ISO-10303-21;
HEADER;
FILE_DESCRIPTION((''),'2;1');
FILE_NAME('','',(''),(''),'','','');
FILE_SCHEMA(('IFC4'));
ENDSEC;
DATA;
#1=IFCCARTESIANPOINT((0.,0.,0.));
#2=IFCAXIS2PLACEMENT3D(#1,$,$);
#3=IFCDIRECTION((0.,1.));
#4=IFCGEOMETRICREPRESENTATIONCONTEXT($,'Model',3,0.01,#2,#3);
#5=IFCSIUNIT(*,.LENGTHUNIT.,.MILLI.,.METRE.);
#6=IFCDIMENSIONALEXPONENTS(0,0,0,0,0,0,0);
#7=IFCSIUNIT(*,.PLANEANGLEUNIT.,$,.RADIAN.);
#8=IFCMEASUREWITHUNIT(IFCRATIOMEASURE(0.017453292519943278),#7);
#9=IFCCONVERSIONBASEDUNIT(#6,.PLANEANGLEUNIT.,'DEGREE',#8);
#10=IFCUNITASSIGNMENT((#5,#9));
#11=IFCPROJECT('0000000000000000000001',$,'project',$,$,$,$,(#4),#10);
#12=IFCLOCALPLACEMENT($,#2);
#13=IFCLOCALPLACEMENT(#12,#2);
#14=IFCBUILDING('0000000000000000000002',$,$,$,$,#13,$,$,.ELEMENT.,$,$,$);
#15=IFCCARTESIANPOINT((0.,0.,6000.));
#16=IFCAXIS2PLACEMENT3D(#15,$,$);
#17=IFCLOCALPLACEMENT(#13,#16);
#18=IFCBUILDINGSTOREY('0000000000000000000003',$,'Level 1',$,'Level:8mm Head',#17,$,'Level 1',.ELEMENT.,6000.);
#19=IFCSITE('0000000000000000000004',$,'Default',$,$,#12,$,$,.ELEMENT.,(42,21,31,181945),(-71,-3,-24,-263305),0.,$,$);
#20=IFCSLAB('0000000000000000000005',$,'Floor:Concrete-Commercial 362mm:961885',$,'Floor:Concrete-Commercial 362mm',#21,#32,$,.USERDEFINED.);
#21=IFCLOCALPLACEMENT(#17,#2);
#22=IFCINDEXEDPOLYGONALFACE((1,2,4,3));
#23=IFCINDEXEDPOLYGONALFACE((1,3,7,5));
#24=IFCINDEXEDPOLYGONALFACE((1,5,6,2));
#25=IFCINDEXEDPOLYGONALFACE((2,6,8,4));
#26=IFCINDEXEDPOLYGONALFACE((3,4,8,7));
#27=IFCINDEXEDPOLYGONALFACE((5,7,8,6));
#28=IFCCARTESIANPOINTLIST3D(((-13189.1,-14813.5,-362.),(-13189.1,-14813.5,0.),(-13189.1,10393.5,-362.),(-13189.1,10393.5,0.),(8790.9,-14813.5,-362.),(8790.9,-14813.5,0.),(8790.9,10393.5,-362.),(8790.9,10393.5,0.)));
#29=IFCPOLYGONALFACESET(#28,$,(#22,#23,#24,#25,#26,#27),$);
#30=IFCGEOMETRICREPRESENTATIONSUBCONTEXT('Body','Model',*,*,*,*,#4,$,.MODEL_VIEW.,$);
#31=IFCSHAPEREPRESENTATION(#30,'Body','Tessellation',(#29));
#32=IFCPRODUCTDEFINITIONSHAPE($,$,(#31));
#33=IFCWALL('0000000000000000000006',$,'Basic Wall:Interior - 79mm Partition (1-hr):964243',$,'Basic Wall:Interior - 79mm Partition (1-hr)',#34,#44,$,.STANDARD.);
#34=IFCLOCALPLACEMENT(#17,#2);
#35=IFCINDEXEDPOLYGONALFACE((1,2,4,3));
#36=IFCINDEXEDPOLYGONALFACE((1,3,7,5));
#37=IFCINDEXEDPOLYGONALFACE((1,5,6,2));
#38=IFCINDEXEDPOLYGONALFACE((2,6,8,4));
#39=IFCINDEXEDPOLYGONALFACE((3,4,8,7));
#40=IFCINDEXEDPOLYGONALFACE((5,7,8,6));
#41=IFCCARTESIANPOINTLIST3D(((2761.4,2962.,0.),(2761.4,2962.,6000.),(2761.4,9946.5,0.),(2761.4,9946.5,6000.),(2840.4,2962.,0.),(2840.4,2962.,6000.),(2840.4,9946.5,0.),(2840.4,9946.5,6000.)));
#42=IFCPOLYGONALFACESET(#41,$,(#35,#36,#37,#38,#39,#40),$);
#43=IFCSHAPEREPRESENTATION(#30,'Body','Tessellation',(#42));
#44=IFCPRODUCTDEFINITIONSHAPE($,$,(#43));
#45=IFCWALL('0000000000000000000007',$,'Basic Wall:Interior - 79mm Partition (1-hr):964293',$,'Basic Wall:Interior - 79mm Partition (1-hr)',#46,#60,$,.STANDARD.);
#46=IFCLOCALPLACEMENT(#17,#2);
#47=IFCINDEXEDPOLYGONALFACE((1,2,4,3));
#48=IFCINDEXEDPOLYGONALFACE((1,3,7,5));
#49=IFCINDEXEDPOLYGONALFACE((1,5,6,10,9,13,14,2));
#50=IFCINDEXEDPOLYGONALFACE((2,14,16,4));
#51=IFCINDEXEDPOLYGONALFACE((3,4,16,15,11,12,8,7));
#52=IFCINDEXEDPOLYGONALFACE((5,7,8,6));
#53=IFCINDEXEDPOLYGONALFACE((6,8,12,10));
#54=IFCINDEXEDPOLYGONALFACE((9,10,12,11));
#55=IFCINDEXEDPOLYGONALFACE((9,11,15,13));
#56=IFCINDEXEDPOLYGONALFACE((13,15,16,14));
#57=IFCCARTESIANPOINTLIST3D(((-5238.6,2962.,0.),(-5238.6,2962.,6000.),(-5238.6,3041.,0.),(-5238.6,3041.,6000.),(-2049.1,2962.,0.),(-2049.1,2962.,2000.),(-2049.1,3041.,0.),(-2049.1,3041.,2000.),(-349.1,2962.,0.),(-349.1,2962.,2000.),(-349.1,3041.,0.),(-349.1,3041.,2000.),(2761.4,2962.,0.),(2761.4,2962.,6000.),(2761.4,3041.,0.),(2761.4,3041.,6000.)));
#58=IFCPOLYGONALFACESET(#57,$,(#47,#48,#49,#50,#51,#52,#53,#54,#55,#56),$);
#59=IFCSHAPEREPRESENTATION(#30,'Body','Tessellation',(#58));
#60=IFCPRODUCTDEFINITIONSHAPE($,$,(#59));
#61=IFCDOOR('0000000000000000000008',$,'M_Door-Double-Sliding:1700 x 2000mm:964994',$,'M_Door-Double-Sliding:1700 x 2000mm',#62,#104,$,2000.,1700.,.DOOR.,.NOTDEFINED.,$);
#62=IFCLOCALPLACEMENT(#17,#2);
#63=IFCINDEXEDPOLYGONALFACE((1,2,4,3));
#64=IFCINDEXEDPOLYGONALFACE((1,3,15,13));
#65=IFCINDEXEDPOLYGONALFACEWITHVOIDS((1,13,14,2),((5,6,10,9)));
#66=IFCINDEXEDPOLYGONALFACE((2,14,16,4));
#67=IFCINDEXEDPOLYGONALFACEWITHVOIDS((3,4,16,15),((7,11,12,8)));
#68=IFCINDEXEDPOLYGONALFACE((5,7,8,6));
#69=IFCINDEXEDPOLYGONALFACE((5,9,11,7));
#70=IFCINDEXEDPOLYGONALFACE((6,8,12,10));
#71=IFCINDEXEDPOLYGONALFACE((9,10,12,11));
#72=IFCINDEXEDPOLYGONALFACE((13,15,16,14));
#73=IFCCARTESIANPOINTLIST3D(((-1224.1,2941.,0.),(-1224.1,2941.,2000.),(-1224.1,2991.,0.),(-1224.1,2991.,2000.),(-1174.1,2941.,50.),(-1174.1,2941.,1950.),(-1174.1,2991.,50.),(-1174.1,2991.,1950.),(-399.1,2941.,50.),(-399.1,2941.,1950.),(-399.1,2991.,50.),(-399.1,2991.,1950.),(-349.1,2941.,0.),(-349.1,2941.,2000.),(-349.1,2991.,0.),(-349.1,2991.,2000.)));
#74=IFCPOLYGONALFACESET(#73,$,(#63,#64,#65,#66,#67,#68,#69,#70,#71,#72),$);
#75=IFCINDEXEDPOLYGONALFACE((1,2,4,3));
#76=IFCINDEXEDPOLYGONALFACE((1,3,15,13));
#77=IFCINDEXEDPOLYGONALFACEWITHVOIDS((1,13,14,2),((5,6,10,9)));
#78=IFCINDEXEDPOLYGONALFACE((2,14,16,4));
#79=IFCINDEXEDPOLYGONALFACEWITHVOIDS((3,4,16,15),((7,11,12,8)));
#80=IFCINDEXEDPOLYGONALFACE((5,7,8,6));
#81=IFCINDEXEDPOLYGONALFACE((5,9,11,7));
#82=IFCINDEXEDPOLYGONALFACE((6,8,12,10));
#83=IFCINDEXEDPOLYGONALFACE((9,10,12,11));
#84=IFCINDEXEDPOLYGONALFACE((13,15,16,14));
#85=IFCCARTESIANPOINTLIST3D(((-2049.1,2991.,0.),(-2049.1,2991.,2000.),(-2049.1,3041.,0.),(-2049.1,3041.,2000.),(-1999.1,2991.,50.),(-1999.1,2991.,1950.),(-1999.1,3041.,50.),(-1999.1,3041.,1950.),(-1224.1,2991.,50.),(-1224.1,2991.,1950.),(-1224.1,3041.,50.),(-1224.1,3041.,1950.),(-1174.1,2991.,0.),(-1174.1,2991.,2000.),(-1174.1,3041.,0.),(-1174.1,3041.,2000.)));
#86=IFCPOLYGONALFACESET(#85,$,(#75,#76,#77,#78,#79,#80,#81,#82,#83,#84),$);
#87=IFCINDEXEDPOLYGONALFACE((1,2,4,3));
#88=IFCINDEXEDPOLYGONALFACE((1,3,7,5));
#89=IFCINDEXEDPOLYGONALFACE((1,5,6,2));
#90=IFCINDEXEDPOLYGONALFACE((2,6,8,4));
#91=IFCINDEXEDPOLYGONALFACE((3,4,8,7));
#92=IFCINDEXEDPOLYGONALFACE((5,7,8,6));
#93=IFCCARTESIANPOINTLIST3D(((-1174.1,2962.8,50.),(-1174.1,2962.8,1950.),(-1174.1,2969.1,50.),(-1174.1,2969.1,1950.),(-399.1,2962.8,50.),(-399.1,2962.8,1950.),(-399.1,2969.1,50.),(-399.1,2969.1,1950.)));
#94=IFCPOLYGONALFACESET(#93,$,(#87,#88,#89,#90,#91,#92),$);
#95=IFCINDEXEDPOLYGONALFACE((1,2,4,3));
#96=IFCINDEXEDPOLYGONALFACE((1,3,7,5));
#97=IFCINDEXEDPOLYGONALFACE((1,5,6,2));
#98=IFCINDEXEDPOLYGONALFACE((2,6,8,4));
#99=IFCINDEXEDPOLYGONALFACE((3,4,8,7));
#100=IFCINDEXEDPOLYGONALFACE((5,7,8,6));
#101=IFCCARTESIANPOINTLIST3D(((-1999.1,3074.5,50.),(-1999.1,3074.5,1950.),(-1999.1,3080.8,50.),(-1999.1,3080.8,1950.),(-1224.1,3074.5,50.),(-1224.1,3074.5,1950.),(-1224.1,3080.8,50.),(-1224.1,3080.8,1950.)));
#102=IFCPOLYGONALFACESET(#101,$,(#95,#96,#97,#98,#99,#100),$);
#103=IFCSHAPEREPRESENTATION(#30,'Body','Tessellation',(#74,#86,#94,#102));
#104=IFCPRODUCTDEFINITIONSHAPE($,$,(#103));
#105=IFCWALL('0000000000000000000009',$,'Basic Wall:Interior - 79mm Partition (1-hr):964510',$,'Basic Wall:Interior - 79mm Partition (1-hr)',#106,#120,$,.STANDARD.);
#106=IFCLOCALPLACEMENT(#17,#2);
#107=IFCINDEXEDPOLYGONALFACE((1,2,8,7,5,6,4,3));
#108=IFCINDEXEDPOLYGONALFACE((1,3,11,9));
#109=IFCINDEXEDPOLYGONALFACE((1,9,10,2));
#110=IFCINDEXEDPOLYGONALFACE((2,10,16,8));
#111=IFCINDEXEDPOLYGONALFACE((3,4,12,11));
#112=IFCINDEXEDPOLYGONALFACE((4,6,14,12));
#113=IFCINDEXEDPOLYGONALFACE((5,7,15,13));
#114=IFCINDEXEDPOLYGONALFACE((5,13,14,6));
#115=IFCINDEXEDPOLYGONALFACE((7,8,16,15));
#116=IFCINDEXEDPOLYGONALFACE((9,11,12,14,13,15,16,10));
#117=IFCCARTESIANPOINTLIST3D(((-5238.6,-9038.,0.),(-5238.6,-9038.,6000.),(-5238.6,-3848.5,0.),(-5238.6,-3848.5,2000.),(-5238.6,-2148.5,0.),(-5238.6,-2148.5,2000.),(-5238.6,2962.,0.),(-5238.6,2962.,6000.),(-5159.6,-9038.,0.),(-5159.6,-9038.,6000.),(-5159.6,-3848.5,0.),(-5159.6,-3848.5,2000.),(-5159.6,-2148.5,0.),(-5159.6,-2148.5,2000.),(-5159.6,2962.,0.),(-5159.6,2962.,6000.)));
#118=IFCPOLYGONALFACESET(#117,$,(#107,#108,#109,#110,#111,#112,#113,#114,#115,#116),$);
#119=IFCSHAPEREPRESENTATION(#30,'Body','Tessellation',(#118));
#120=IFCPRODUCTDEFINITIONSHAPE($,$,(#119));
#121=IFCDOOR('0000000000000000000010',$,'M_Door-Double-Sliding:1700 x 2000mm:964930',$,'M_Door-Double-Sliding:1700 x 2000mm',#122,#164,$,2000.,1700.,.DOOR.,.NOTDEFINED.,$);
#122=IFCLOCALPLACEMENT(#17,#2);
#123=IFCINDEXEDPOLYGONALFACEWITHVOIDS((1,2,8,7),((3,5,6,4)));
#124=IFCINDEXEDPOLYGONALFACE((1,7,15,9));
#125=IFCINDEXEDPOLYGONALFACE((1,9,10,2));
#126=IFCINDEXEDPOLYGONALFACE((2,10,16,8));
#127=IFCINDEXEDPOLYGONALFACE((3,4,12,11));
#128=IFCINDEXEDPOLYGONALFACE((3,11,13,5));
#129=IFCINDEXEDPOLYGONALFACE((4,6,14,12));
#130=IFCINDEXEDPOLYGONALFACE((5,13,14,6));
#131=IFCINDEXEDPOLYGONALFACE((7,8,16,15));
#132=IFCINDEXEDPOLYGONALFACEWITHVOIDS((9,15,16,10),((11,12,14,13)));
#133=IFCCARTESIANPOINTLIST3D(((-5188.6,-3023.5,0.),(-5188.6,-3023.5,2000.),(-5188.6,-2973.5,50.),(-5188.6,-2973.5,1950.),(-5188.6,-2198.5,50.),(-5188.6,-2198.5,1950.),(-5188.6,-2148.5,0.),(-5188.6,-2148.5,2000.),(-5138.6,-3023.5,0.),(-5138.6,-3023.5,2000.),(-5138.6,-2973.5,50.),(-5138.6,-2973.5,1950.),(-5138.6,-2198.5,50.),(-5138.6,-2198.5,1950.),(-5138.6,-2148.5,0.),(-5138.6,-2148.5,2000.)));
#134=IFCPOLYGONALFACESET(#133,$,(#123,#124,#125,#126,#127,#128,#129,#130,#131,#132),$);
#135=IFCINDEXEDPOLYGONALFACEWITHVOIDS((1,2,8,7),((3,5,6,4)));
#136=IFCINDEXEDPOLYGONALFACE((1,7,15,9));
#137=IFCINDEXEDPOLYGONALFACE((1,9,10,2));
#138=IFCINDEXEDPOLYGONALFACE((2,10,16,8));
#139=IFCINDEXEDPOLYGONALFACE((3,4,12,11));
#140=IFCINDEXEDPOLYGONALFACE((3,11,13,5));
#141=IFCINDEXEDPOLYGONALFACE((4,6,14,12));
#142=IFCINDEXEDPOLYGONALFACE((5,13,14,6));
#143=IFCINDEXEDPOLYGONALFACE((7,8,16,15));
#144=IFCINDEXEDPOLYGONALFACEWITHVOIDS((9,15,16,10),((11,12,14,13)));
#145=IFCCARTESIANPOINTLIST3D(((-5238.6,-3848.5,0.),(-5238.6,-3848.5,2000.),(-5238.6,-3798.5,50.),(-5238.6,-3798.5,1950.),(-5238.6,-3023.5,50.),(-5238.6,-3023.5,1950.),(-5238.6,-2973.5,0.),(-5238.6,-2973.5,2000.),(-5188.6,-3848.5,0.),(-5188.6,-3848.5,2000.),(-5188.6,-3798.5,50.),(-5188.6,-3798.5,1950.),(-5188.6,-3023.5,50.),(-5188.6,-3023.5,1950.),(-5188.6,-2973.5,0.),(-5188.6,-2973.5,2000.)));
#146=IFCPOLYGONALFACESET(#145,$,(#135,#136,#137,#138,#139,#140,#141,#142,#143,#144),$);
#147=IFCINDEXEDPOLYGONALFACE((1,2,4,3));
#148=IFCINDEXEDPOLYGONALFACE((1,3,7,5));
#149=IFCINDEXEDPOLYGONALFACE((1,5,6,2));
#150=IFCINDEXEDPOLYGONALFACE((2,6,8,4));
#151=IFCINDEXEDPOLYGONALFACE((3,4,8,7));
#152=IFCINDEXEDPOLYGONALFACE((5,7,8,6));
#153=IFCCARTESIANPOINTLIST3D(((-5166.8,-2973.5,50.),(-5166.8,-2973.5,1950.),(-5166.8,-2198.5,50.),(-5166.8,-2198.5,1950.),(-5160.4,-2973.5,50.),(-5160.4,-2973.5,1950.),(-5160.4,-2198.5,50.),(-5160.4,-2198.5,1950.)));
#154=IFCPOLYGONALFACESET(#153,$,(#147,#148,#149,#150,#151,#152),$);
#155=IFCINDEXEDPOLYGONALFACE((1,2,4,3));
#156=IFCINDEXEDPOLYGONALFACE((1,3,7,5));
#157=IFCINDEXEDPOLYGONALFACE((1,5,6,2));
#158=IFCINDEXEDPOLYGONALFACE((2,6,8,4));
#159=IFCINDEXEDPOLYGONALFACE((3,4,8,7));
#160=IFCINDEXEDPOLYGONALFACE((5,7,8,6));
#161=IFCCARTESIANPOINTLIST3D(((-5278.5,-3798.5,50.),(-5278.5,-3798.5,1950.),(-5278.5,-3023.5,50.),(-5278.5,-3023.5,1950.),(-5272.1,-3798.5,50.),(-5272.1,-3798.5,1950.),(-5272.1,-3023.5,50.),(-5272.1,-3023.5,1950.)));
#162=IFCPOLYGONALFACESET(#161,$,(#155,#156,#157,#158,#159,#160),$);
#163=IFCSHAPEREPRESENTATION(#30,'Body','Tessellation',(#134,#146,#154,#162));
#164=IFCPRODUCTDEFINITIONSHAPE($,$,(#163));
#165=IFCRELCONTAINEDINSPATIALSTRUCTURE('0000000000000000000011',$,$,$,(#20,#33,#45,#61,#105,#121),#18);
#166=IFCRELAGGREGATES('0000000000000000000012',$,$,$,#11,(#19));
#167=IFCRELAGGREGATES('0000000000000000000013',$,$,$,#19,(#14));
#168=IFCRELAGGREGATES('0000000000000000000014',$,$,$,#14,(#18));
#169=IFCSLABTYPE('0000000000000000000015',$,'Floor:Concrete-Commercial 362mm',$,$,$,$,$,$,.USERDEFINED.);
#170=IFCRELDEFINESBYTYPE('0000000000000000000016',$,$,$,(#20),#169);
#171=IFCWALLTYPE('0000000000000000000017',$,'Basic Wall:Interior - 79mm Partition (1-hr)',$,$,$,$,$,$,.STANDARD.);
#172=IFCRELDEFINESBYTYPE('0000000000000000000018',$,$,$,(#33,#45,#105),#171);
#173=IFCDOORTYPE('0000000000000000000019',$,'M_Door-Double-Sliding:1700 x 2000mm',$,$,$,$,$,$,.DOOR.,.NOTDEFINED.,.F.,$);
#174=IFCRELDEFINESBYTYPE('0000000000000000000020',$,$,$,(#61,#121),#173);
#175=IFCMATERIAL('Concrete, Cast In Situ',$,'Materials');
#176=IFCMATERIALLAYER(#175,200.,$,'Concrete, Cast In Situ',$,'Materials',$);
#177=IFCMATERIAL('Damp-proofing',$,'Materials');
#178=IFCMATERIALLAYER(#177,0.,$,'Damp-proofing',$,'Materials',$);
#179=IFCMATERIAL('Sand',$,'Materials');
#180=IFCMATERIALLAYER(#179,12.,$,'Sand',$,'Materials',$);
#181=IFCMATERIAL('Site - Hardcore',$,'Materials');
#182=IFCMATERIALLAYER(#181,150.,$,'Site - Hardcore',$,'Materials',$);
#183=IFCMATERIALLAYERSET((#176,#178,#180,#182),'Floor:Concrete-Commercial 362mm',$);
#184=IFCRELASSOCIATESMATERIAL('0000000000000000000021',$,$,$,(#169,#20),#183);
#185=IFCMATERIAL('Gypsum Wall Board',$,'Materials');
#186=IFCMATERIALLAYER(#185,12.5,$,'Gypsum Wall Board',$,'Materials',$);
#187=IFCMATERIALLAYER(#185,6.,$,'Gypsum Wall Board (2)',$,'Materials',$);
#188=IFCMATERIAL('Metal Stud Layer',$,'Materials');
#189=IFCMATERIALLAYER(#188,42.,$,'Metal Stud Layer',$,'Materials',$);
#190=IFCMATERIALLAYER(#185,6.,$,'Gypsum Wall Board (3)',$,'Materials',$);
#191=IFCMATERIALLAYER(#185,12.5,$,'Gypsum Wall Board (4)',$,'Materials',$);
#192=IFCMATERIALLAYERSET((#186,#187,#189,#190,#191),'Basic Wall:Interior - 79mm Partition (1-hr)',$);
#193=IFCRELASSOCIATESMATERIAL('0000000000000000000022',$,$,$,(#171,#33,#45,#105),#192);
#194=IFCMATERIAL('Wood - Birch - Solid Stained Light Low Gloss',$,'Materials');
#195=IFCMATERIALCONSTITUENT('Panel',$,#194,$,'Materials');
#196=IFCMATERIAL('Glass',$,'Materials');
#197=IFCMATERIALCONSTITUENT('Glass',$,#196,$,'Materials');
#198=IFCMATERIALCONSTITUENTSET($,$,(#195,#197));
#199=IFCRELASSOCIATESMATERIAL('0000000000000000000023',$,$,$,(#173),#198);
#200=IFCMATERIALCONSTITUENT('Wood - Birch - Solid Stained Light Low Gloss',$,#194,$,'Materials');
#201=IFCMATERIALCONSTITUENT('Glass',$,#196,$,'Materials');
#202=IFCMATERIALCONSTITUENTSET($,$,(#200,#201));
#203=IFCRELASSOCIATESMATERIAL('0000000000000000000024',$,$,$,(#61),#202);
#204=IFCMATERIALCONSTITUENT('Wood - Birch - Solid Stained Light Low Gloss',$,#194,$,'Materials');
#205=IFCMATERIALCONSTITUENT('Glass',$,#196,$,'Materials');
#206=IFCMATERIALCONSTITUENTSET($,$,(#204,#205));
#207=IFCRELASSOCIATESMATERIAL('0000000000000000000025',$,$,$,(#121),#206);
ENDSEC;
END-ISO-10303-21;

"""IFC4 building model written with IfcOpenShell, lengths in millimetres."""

from ifc_helpers import new_model, entity, si_unit, converted_unit, direction, frame, frame_2d, origin, origin_2d_with_axis, place, context, subcontext, project, spatial, polyline, rectangle, outline, extrude, source, transform, mapped, material, layer, layer_set, layer_usage, constituent, constituent_set, type_object, type_shapes, element, fill, save


model = new_model("IFC4")

# Units and contexts
model_context = context("Model", 3, precision=0.01, world=origin(), true_north=direction((0.0, 1.0)))
body_context = subcontext(model_context, "Body", "Model", "MODEL_VIEW")
ifc_project = project(units=[si_unit("LENGTHUNIT", "METRE", prefix="MILLI"), converted_unit("PLANEANGLEUNIT", "DEGREE", entity("IfcRatioMeasure", 0.017453292519943278), si_unit("PLANEANGLEUNIT", "RADIAN"), dimensions=[0, 0, 0, 0, 0, 0, 0])], contexts=[model_context])

# Site, building, storey
site_placement = place(None, origin())
site = spatial("IfcSite", under=ifc_project, at=site_placement, Name="Default", CompositionType="ELEMENT", RefLatitude=(42, 21, 31, 181945), RefLongitude=(-71, -3, -24, -263305), RefElevation=0.0)
building_placement = place(site_placement, origin())
building = spatial("IfcBuilding", under=site, at=building_placement, CompositionType="ELEMENT")
storey_placement = place(building_placement, frame((0.0, 0.0, 6000.0)))
storey = spatial("IfcBuildingStorey", under=building, at=storey_placement, Name="Level 1", ObjectType="Level:8mm Head", LongName="Level 1", CompositionType="ELEMENT", Elevation=6000.0)

# Slab
ifc_material_1 = material(Name="Concrete, Cast In Situ", Category="Materials")
ifc_layer_1 = layer(ifc_material_1, 200.0, Name="Concrete, Cast In Situ", Category="Materials")
ifc_material_2 = material(Name="Damp-proofing", Category="Materials")
ifc_layer_2 = layer(ifc_material_2, 0.0, Name="Damp-proofing", Category="Materials")
ifc_material_3 = material(Name="Sand", Category="Materials")
ifc_layer_3 = layer(ifc_material_3, 12.0, Name="Sand", Category="Materials")
ifc_material_4 = material(Name="Site - Hardcore", Category="Materials")
ifc_layer_4 = layer(ifc_material_4, 150.0, Name="Site - Hardcore", Category="Materials")
ifc_layer_set_1 = layer_set([ifc_layer_1, ifc_layer_2, ifc_layer_3, ifc_layer_4], Name="Floor:Concrete-Commercial 362mm")
ifc_layer_usage_1 = layer_usage(ifc_layer_set_1, "AXIS3", "POSITIVE", 0.0)
slab_type = type_object("IfcSlabType", Name="Floor:Concrete-Commercial 362mm", PredefinedType="USERDEFINED", material=ifc_layer_set_1)
slab_placement = place(storey_placement, origin())
element("IfcSlab", 1, at=slab_placement, inside=storey, type_object=slab_type, material=ifc_layer_usage_1, Name="Floor:Concrete-Commercial 362mm:961885", ObjectType="Floor:Concrete-Commercial 362mm", PredefinedType="USERDEFINED", context=body_context, shape_type="SweptSolid", body=[
    extrude(rectangle(XDim=25207.0, YDim=21980.0, at=frame_2d((0.0, 0.0), x_axis=(1.0, 0.0))), frame((-2199.1, -2210.0, 0.0), z_axis=(0.0, 0.0, -1.0), x_axis=(0.0, 1.0, 0.0)), (0.0, 0.0, 1.0), 362.0),
])

# Wall
ifc_material_5 = material(Name="Gypsum Wall Board", Category="Materials")
ifc_layer_5 = layer(ifc_material_5, 12.5, Name="Gypsum Wall Board", Category="Materials")
ifc_layer_6 = layer(ifc_material_5, 6.0, Name="Gypsum Wall Board (2)", Category="Materials")
ifc_material_6 = material(Name="Metal Stud Layer", Category="Materials")
ifc_layer_7 = layer(ifc_material_6, 42.0, Name="Metal Stud Layer", Category="Materials")
ifc_layer_8 = layer(ifc_material_5, 6.0, Name="Gypsum Wall Board (3)", Category="Materials")
ifc_layer_9 = layer(ifc_material_5, 12.5, Name="Gypsum Wall Board (4)", Category="Materials")
ifc_layer_set_2 = layer_set([ifc_layer_5, ifc_layer_6, ifc_layer_7, ifc_layer_8, ifc_layer_9], Name="Basic Wall:Interior - 79mm Partition (1-hr)")
ifc_layer_usage_2 = layer_usage(ifc_layer_set_2, "AXIS2", "NEGATIVE", 39.5)
wall_type = type_object("IfcWallType", Name="Basic Wall:Interior - 79mm Partition (1-hr)", PredefinedType="STANDARD", material=ifc_layer_set_2)
wall_1_placement = place(storey_placement, frame((2800.9, 9946.5, 0.0), z_axis=(0.0, 0.0, 1.0), x_axis=(0.0, -1.0, 0.0)))
element("IfcWall", 2, at=wall_1_placement, inside=storey, type_object=wall_type, material=ifc_layer_usage_2, Name="Basic Wall:Interior - 79mm Partition (1-hr):964243", ObjectType="Basic Wall:Interior - 79mm Partition (1-hr)", PredefinedType="STANDARD", context=body_context, shape_type="SweptSolid", body=[
    extrude(rectangle(XDim=6984.5, YDim=79.0, at=frame_2d((3492.3, 0.0), x_axis=(-1.0, 0.0))), origin(), (0.0, 0.0, 1.0), 6000.0),
])

# Walls, openings, doors
wall_2_placement = place(storey_placement, frame((2761.4, 3001.5, 0.0), z_axis=(0.0, 0.0, 1.0), x_axis=(-1.0, 0.0, 0.0)))
wall_2 = element("IfcWall", 3, at=wall_2_placement, inside=storey, type_object=wall_type, material=ifc_layer_usage_2, Name="Basic Wall:Interior - 79mm Partition (1-hr):964293", ObjectType="Basic Wall:Interior - 79mm Partition (1-hr)", PredefinedType="STANDARD", context=body_context, shape_type="SweptSolid", body=[
    extrude(rectangle(XDim=8000.0, YDim=79.0, at=frame_2d((4000.0, 0.0), x_axis=(-1.0, 0.0))), origin(), (0.0, 0.0, 1.0), 6000.0),
])
opening_1_placement = place(wall_2_placement, frame((4810.5, 39.5, 0.0)))
opening_1 = element("IfcOpeningElement", 4, at=opening_1_placement, cuts=wall_2, PredefinedType="OPENING", context=body_context, shape_type="SweptSolid", body=[
    extrude(rectangle(XDim=2000.0, YDim=1700.0, at=frame_2d((1000.0, 850.0), x_axis=(-1.0, 0.0))), frame((0.0, 0.0, 0.0), z_axis=(0.0, -1.0, 0.0), x_axis=(0.0, 0.0, 1.0)), (0.0, 0.0, 1.0), 79.0),
])
ifc_material_7 = material(Name="Wood - Birch - Solid Stained Light Low Gloss", Category="Materials")
ifc_constituent_1 = constituent(ifc_material_7, Name="Wood - Birch - Solid Stained Light Low Gloss", Category="Materials")
ifc_material_8 = material(Name="Glass", Category="Materials")
ifc_constituent_2 = constituent(ifc_material_8, Name="Glass", Category="Materials")
ifc_constituent_set_1 = constituent_set(constituents=[ifc_constituent_1, ifc_constituent_2])
ifc_constituent_3 = constituent(ifc_material_7, Name="Panel", Category="Materials")
ifc_constituent_4 = constituent(ifc_material_8, Name="Glass", Category="Materials")
ifc_constituent_set_2 = constituent_set(constituents=[ifc_constituent_3, ifc_constituent_4])
door_type = type_object("IfcDoorType", Name="M_Door-Double-Sliding:1700 x 2000mm", OperationType="NOTDEFINED", ParameterTakesPrecedence=False, PredefinedType="DOOR", material=ifc_constituent_set_2)
shared_shape_1 = source(origin(), body_context, "Body", "SweptSolid", [
    extrude(outline(polyline([(-437.5, -1000.0), (437.5, -1000.0), (437.5, 1000.0), (-437.5, 1000.0), (-437.5, -1000.0)]), holes=[polyline([(-387.5, -950.0), (-387.5, 950.0), (387.5, 950.0), (387.5, -950.0), (-387.5, -950.0)])]), frame((1262.5, -21.0, 1000.0), z_axis=(0.0, 1.0, 0.0), x_axis=(1.0, 0.0, 0.0)), (0.0, 0.0, 1.0), 50.0),
    extrude(outline(polyline([(-1000.0, -437.5), (1000.0, -437.5), (1000.0, 437.5), (-1000.0, 437.5), (-1000.0, -437.5)]), holes=[polyline([(-950.0, -387.5), (-950.0, 387.5), (950.0, 387.5), (950.0, -387.5), (-950.0, -387.5)])]), frame((437.5, 29.0, 1000.0), z_axis=(0.0, 1.0, 0.0), x_axis=(0.0, 0.0, -1.0)), (0.0, 0.0, 1.0), 50.0),
    extrude(rectangle(XDim=6.3, YDim=775.0, at=frame_2d((0.0, 0.0), x_axis=(1.0, 0.0))), frame((1262.5, 4.0, 50.0), z_axis=(0.0, 0.0, 1.0), x_axis=(0.0, -1.0, 0.0)), (0.0, 0.0, 1.0), 1900.0),
    extrude(rectangle(XDim=6.4, YDim=775.0, at=origin_2d_with_axis()), frame((437.5, 115.7, 50.0), z_axis=(0.0, 0.0, 1.0), x_axis=(0.0, 1.0, 0.0)), (0.0, 0.0, 1.0), 1900.0),
])
type_shapes(door_type, [shared_shape_1])
door_1_placement = place(opening_1_placement, frame((0.0, 0.0, 0.0), z_axis=(0.0, 0.0, 1.0), x_axis=(-1.0, 0.0, 0.0)))
door_1 = element("IfcDoor", 5, at=door_1_placement, inside=storey, type_object=door_type, material=ifc_constituent_set_1, Name="M_Door-Double-Sliding:1700 x 2000mm:964994", ObjectType="M_Door-Double-Sliding:1700 x 2000mm", OperationType="NOTDEFINED", OverallHeight=2000.0, OverallWidth=1700.0, PredefinedType="DOOR", context=body_context, shape_type="MappedRepresentation", body=[
    mapped(shared_shape_1, transform((0.0, 0.0, 0.0), scale=1.0)),
])
fill(opening_1, door_1)
wall_3_placement = place(storey_placement, frame((-5199.1, 2962.0, 0.0), z_axis=(0.0, 0.0, 1.0), x_axis=(0.0, -1.0, 0.0)))
wall_3 = element("IfcWall", 6, at=wall_3_placement, inside=storey, type_object=wall_type, material=ifc_layer_usage_2, Name="Basic Wall:Interior - 79mm Partition (1-hr):964510", ObjectType="Basic Wall:Interior - 79mm Partition (1-hr)", PredefinedType="STANDARD", context=body_context, shape_type="SweptSolid", body=[
    extrude(rectangle(XDim=12000.0, YDim=79.0, at=frame_2d((6000.0, 0.0), x_axis=(1.0, 0.0))), origin(), (0.0, 0.0, 1.0), 6000.0),
])
opening_2_placement = place(wall_3_placement, frame((6810.5, 39.5, 0.0)))
opening_2 = element("IfcOpeningElement", 7, at=opening_2_placement, cuts=wall_3, PredefinedType="OPENING", context=body_context, shape_type="SweptSolid", body=[
    extrude(rectangle(XDim=2000.0, YDim=1700.0, at=frame_2d((1000.0, 850.0), x_axis=(-1.0, 0.0))), frame((0.0, 0.0, 0.0), z_axis=(0.0, -1.0, 0.0), x_axis=(0.0, 0.0, 1.0)), (0.0, 0.0, 1.0), 79.0),
])
ifc_constituent_5 = constituent(ifc_material_7, Name="Wood - Birch - Solid Stained Light Low Gloss", Category="Materials")
ifc_constituent_6 = constituent(ifc_material_8, Name="Glass", Category="Materials")
ifc_constituent_set_3 = constituent_set(constituents=[ifc_constituent_5, ifc_constituent_6])
door_2_placement = place(opening_2_placement, frame((0.0, 0.0, 0.0), z_axis=(0.0, 0.0, 1.0), x_axis=(-1.0, 0.0, 0.0)))
door_2 = element("IfcDoor", 8, at=door_2_placement, inside=storey, type_object=door_type, material=ifc_constituent_set_3, Name="M_Door-Double-Sliding:1700 x 2000mm:964930", ObjectType="M_Door-Double-Sliding:1700 x 2000mm", OperationType="NOTDEFINED", OverallHeight=2000.0, OverallWidth=1700.0, PredefinedType="DOOR", context=body_context, shape_type="MappedRepresentation", body=[
    mapped(shared_shape_1, transform((0.0, 0.0, 0.0), scale=1.0)),
])
fill(opening_2, door_2)

save(model, "model.ifc")
